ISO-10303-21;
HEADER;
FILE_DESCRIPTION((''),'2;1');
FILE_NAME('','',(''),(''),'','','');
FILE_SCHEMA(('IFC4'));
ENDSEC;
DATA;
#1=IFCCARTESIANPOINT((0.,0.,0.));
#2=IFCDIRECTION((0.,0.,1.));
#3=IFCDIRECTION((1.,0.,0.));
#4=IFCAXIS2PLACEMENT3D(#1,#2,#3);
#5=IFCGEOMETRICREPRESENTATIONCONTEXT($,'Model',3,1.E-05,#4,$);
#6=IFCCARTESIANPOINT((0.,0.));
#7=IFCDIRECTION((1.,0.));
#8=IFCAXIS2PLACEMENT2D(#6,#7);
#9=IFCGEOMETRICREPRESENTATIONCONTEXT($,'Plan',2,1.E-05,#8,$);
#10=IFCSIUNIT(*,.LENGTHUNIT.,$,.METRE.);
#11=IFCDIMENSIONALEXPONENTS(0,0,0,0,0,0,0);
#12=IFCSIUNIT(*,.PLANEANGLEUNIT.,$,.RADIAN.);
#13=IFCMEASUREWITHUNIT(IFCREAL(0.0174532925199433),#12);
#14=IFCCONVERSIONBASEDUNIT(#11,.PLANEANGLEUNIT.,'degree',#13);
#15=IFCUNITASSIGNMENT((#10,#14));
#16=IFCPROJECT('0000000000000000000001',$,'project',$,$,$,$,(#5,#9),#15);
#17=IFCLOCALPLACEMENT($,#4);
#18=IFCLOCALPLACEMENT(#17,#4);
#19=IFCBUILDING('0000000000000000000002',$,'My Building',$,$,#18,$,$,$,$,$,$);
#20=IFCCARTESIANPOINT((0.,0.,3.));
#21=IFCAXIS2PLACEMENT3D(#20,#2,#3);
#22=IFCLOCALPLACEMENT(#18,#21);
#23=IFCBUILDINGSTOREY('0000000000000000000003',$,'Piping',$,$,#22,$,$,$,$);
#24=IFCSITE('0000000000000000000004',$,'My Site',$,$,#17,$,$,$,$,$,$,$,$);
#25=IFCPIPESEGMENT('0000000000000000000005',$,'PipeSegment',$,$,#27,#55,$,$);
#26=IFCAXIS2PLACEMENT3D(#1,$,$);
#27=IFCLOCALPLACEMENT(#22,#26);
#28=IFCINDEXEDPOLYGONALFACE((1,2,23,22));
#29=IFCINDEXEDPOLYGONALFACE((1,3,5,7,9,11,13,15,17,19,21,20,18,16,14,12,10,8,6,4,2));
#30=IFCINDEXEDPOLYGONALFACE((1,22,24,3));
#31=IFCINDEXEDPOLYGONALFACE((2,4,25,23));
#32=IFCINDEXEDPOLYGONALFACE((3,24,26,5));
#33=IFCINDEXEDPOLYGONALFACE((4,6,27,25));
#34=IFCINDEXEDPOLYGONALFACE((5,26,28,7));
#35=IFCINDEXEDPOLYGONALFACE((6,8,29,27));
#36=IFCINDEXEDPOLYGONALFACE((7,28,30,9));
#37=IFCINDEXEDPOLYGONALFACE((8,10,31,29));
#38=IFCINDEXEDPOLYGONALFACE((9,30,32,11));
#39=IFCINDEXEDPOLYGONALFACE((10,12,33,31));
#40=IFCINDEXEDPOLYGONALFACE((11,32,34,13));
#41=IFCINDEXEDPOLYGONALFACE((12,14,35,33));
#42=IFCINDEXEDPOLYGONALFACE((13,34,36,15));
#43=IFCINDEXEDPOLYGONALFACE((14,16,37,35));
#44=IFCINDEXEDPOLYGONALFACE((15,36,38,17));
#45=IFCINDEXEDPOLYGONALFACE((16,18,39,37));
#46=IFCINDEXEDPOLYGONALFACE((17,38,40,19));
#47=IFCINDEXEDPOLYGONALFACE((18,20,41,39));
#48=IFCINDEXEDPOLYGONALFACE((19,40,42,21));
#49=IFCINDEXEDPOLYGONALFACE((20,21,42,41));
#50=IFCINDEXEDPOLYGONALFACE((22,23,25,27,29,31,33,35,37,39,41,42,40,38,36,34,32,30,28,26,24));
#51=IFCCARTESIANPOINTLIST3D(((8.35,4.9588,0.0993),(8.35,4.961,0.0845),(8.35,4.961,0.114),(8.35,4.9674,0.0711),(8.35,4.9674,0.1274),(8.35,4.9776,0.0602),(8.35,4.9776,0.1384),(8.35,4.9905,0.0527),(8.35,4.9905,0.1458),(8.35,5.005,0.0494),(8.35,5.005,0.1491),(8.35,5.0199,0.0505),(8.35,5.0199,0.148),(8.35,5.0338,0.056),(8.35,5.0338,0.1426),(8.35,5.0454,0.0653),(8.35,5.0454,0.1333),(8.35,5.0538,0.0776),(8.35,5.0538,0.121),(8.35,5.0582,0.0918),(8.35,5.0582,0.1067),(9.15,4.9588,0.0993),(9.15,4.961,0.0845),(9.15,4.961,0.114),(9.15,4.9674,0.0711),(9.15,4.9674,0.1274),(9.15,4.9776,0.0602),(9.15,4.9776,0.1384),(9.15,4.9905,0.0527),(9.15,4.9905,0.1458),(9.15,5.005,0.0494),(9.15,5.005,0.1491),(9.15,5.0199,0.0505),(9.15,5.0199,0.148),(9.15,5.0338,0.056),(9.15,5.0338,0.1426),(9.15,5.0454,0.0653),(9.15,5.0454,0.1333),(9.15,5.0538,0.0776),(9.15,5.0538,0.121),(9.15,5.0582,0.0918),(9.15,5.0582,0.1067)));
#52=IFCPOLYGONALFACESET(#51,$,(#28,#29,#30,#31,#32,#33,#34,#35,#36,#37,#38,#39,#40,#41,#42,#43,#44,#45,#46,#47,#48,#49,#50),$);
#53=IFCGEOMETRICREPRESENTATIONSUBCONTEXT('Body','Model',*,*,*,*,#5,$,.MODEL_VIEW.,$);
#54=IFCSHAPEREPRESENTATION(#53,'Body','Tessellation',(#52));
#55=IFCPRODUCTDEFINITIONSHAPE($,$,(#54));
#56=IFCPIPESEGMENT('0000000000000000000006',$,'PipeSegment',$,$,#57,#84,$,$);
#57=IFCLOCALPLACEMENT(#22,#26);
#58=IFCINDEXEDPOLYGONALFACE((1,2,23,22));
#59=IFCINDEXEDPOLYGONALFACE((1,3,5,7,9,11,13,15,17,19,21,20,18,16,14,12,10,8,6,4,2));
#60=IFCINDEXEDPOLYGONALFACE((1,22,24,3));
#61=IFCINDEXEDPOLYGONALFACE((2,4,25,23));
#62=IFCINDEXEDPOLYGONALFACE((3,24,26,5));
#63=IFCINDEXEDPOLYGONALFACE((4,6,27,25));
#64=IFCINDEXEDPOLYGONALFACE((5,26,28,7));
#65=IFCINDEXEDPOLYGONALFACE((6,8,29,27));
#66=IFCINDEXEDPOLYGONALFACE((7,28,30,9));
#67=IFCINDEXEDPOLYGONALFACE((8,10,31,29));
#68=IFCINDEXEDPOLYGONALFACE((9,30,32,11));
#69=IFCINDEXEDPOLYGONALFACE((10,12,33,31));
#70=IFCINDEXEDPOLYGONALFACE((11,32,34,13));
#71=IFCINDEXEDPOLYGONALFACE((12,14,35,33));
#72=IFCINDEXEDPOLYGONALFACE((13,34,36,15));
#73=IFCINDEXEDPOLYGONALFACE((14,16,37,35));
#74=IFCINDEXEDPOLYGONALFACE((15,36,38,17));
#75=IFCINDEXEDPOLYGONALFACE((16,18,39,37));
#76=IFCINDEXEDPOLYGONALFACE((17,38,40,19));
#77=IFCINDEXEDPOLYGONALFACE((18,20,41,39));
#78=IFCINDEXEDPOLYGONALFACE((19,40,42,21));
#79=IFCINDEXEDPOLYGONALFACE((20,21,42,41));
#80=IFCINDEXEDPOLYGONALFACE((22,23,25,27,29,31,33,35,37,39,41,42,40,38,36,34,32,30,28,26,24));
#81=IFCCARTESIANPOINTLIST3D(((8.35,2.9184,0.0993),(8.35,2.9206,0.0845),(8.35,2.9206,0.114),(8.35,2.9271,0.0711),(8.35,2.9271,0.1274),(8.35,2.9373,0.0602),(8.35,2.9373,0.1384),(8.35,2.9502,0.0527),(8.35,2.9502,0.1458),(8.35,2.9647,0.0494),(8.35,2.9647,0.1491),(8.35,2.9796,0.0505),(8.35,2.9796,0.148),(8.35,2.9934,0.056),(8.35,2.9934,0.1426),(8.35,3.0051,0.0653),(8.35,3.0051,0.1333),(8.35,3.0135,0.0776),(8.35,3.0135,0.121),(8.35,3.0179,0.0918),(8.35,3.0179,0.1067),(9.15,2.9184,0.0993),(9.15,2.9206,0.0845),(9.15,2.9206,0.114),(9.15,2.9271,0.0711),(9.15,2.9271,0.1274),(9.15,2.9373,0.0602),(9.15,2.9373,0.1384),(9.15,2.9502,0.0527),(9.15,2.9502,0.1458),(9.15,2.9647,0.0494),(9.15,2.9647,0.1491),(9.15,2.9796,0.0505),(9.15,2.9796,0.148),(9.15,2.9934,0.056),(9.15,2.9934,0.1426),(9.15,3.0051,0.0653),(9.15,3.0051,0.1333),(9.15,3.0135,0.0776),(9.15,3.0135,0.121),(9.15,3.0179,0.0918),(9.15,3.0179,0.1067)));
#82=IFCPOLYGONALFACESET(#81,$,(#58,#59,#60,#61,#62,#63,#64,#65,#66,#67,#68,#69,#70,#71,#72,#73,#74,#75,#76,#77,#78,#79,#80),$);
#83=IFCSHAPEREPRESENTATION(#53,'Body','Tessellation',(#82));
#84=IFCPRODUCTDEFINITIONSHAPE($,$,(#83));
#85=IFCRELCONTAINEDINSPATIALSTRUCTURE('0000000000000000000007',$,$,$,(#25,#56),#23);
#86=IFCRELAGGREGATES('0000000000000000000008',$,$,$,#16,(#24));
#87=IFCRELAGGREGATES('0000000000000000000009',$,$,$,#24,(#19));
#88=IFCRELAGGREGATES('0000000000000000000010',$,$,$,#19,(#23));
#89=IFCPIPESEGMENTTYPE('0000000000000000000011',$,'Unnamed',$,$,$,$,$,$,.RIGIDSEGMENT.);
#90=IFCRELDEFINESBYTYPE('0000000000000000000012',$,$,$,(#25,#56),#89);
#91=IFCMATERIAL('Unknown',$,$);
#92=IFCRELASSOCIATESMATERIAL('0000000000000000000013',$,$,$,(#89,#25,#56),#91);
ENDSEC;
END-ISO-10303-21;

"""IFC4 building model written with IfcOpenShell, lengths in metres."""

from ifc_helpers import new_model, entity, si_unit, converted_unit, frame, origin_with_axes, origin_2d_with_axis, place, context, subcontext, project, spatial, circle, extrude, material, material_profile, profile_set, profile_usage, type_object, element, save


model = new_model("IFC4")

# Units and contexts
model_context = context("Model", 3, precision=1e-05, world=origin_with_axes())
plan_context = context("Plan", 2, precision=1e-05, world=origin_2d_with_axis())
body_context = subcontext(model_context, "Body", "Model", "MODEL_VIEW")
ifc_project = project(units=[si_unit("LENGTHUNIT", "METRE"), converted_unit("PLANEANGLEUNIT", "degree", entity("IfcReal", 0.0174532925199433), si_unit("PLANEANGLEUNIT", "RADIAN"), dimensions=[0, 0, 0, 0, 0, 0, 0])], contexts=[model_context, plan_context])

# Site, building, storey
site_placement = place(None, origin_with_axes())
site = spatial("IfcSite", under=ifc_project, at=site_placement, Name="My Site")
building_placement = place(site_placement, origin_with_axes())
building = spatial("IfcBuilding", under=site, at=building_placement, Name="My Building")
storey_placement = place(building_placement, frame((0.0, 0.0, 3.0), z_axis=(0.0, 0.0, 1.0), x_axis=(1.0, 0.0, 0.0)))
storey = spatial("IfcBuildingStorey", under=building, at=storey_placement, Name="Piping")

# Pipe segments
ifc_material = material(Name="Unknown")
ifc_material_profile = material_profile(ifc_material, circle(Radius=0.05))
ifc_profile_set = profile_set([ifc_material_profile])
pipe_segment_type = type_object("IfcPipeSegmentType", Name="Unnamed", PredefinedType="RIGIDSEGMENT", material=ifc_profile_set)
ifc_profile_usage_1 = profile_usage(ifc_profile_set, cardinal=8)
pipe_segment_1_placement = place(storey_placement, frame((9.15, 5.0088, 0.1493), z_axis=(-1.0, 0.0, 0.0), x_axis=(0.0, -1.0, 0.0)))
element("IfcPipeSegment", 1, at=pipe_segment_1_placement, inside=storey, type_object=pipe_segment_type, material=ifc_profile_usage_1, Name="PipeSegment", context=body_context, shape_type="SweptSolid", body=[
    extrude(circle(Radius=0.05), frame((0.0, -0.05, 0.0), z_axis=(0.0, 0.0, 1.0), x_axis=(1.0, 0.0, 0.0)), (0.0, 0.0, 1.0), 0.8),
])
ifc_profile_usage_2 = profile_usage(ifc_profile_set, cardinal=8)
pipe_segment_2_placement = place(storey_placement, frame((9.15, 2.9684, 0.1493), z_axis=(-1.0, 0.0, 0.0), x_axis=(0.0, -1.0, 0.0)))
element("IfcPipeSegment", 2, at=pipe_segment_2_placement, inside=storey, type_object=pipe_segment_type, material=ifc_profile_usage_2, Name="PipeSegment", context=body_context, shape_type="SweptSolid", body=[
    extrude(circle(Radius=0.05), frame((0.0, -0.05, 0.0), z_axis=(0.0, 0.0, 1.0), x_axis=(1.0, 0.0, 0.0)), (0.0, 0.0, 1.0), 0.8),
])

save(model, "model.ifc")
